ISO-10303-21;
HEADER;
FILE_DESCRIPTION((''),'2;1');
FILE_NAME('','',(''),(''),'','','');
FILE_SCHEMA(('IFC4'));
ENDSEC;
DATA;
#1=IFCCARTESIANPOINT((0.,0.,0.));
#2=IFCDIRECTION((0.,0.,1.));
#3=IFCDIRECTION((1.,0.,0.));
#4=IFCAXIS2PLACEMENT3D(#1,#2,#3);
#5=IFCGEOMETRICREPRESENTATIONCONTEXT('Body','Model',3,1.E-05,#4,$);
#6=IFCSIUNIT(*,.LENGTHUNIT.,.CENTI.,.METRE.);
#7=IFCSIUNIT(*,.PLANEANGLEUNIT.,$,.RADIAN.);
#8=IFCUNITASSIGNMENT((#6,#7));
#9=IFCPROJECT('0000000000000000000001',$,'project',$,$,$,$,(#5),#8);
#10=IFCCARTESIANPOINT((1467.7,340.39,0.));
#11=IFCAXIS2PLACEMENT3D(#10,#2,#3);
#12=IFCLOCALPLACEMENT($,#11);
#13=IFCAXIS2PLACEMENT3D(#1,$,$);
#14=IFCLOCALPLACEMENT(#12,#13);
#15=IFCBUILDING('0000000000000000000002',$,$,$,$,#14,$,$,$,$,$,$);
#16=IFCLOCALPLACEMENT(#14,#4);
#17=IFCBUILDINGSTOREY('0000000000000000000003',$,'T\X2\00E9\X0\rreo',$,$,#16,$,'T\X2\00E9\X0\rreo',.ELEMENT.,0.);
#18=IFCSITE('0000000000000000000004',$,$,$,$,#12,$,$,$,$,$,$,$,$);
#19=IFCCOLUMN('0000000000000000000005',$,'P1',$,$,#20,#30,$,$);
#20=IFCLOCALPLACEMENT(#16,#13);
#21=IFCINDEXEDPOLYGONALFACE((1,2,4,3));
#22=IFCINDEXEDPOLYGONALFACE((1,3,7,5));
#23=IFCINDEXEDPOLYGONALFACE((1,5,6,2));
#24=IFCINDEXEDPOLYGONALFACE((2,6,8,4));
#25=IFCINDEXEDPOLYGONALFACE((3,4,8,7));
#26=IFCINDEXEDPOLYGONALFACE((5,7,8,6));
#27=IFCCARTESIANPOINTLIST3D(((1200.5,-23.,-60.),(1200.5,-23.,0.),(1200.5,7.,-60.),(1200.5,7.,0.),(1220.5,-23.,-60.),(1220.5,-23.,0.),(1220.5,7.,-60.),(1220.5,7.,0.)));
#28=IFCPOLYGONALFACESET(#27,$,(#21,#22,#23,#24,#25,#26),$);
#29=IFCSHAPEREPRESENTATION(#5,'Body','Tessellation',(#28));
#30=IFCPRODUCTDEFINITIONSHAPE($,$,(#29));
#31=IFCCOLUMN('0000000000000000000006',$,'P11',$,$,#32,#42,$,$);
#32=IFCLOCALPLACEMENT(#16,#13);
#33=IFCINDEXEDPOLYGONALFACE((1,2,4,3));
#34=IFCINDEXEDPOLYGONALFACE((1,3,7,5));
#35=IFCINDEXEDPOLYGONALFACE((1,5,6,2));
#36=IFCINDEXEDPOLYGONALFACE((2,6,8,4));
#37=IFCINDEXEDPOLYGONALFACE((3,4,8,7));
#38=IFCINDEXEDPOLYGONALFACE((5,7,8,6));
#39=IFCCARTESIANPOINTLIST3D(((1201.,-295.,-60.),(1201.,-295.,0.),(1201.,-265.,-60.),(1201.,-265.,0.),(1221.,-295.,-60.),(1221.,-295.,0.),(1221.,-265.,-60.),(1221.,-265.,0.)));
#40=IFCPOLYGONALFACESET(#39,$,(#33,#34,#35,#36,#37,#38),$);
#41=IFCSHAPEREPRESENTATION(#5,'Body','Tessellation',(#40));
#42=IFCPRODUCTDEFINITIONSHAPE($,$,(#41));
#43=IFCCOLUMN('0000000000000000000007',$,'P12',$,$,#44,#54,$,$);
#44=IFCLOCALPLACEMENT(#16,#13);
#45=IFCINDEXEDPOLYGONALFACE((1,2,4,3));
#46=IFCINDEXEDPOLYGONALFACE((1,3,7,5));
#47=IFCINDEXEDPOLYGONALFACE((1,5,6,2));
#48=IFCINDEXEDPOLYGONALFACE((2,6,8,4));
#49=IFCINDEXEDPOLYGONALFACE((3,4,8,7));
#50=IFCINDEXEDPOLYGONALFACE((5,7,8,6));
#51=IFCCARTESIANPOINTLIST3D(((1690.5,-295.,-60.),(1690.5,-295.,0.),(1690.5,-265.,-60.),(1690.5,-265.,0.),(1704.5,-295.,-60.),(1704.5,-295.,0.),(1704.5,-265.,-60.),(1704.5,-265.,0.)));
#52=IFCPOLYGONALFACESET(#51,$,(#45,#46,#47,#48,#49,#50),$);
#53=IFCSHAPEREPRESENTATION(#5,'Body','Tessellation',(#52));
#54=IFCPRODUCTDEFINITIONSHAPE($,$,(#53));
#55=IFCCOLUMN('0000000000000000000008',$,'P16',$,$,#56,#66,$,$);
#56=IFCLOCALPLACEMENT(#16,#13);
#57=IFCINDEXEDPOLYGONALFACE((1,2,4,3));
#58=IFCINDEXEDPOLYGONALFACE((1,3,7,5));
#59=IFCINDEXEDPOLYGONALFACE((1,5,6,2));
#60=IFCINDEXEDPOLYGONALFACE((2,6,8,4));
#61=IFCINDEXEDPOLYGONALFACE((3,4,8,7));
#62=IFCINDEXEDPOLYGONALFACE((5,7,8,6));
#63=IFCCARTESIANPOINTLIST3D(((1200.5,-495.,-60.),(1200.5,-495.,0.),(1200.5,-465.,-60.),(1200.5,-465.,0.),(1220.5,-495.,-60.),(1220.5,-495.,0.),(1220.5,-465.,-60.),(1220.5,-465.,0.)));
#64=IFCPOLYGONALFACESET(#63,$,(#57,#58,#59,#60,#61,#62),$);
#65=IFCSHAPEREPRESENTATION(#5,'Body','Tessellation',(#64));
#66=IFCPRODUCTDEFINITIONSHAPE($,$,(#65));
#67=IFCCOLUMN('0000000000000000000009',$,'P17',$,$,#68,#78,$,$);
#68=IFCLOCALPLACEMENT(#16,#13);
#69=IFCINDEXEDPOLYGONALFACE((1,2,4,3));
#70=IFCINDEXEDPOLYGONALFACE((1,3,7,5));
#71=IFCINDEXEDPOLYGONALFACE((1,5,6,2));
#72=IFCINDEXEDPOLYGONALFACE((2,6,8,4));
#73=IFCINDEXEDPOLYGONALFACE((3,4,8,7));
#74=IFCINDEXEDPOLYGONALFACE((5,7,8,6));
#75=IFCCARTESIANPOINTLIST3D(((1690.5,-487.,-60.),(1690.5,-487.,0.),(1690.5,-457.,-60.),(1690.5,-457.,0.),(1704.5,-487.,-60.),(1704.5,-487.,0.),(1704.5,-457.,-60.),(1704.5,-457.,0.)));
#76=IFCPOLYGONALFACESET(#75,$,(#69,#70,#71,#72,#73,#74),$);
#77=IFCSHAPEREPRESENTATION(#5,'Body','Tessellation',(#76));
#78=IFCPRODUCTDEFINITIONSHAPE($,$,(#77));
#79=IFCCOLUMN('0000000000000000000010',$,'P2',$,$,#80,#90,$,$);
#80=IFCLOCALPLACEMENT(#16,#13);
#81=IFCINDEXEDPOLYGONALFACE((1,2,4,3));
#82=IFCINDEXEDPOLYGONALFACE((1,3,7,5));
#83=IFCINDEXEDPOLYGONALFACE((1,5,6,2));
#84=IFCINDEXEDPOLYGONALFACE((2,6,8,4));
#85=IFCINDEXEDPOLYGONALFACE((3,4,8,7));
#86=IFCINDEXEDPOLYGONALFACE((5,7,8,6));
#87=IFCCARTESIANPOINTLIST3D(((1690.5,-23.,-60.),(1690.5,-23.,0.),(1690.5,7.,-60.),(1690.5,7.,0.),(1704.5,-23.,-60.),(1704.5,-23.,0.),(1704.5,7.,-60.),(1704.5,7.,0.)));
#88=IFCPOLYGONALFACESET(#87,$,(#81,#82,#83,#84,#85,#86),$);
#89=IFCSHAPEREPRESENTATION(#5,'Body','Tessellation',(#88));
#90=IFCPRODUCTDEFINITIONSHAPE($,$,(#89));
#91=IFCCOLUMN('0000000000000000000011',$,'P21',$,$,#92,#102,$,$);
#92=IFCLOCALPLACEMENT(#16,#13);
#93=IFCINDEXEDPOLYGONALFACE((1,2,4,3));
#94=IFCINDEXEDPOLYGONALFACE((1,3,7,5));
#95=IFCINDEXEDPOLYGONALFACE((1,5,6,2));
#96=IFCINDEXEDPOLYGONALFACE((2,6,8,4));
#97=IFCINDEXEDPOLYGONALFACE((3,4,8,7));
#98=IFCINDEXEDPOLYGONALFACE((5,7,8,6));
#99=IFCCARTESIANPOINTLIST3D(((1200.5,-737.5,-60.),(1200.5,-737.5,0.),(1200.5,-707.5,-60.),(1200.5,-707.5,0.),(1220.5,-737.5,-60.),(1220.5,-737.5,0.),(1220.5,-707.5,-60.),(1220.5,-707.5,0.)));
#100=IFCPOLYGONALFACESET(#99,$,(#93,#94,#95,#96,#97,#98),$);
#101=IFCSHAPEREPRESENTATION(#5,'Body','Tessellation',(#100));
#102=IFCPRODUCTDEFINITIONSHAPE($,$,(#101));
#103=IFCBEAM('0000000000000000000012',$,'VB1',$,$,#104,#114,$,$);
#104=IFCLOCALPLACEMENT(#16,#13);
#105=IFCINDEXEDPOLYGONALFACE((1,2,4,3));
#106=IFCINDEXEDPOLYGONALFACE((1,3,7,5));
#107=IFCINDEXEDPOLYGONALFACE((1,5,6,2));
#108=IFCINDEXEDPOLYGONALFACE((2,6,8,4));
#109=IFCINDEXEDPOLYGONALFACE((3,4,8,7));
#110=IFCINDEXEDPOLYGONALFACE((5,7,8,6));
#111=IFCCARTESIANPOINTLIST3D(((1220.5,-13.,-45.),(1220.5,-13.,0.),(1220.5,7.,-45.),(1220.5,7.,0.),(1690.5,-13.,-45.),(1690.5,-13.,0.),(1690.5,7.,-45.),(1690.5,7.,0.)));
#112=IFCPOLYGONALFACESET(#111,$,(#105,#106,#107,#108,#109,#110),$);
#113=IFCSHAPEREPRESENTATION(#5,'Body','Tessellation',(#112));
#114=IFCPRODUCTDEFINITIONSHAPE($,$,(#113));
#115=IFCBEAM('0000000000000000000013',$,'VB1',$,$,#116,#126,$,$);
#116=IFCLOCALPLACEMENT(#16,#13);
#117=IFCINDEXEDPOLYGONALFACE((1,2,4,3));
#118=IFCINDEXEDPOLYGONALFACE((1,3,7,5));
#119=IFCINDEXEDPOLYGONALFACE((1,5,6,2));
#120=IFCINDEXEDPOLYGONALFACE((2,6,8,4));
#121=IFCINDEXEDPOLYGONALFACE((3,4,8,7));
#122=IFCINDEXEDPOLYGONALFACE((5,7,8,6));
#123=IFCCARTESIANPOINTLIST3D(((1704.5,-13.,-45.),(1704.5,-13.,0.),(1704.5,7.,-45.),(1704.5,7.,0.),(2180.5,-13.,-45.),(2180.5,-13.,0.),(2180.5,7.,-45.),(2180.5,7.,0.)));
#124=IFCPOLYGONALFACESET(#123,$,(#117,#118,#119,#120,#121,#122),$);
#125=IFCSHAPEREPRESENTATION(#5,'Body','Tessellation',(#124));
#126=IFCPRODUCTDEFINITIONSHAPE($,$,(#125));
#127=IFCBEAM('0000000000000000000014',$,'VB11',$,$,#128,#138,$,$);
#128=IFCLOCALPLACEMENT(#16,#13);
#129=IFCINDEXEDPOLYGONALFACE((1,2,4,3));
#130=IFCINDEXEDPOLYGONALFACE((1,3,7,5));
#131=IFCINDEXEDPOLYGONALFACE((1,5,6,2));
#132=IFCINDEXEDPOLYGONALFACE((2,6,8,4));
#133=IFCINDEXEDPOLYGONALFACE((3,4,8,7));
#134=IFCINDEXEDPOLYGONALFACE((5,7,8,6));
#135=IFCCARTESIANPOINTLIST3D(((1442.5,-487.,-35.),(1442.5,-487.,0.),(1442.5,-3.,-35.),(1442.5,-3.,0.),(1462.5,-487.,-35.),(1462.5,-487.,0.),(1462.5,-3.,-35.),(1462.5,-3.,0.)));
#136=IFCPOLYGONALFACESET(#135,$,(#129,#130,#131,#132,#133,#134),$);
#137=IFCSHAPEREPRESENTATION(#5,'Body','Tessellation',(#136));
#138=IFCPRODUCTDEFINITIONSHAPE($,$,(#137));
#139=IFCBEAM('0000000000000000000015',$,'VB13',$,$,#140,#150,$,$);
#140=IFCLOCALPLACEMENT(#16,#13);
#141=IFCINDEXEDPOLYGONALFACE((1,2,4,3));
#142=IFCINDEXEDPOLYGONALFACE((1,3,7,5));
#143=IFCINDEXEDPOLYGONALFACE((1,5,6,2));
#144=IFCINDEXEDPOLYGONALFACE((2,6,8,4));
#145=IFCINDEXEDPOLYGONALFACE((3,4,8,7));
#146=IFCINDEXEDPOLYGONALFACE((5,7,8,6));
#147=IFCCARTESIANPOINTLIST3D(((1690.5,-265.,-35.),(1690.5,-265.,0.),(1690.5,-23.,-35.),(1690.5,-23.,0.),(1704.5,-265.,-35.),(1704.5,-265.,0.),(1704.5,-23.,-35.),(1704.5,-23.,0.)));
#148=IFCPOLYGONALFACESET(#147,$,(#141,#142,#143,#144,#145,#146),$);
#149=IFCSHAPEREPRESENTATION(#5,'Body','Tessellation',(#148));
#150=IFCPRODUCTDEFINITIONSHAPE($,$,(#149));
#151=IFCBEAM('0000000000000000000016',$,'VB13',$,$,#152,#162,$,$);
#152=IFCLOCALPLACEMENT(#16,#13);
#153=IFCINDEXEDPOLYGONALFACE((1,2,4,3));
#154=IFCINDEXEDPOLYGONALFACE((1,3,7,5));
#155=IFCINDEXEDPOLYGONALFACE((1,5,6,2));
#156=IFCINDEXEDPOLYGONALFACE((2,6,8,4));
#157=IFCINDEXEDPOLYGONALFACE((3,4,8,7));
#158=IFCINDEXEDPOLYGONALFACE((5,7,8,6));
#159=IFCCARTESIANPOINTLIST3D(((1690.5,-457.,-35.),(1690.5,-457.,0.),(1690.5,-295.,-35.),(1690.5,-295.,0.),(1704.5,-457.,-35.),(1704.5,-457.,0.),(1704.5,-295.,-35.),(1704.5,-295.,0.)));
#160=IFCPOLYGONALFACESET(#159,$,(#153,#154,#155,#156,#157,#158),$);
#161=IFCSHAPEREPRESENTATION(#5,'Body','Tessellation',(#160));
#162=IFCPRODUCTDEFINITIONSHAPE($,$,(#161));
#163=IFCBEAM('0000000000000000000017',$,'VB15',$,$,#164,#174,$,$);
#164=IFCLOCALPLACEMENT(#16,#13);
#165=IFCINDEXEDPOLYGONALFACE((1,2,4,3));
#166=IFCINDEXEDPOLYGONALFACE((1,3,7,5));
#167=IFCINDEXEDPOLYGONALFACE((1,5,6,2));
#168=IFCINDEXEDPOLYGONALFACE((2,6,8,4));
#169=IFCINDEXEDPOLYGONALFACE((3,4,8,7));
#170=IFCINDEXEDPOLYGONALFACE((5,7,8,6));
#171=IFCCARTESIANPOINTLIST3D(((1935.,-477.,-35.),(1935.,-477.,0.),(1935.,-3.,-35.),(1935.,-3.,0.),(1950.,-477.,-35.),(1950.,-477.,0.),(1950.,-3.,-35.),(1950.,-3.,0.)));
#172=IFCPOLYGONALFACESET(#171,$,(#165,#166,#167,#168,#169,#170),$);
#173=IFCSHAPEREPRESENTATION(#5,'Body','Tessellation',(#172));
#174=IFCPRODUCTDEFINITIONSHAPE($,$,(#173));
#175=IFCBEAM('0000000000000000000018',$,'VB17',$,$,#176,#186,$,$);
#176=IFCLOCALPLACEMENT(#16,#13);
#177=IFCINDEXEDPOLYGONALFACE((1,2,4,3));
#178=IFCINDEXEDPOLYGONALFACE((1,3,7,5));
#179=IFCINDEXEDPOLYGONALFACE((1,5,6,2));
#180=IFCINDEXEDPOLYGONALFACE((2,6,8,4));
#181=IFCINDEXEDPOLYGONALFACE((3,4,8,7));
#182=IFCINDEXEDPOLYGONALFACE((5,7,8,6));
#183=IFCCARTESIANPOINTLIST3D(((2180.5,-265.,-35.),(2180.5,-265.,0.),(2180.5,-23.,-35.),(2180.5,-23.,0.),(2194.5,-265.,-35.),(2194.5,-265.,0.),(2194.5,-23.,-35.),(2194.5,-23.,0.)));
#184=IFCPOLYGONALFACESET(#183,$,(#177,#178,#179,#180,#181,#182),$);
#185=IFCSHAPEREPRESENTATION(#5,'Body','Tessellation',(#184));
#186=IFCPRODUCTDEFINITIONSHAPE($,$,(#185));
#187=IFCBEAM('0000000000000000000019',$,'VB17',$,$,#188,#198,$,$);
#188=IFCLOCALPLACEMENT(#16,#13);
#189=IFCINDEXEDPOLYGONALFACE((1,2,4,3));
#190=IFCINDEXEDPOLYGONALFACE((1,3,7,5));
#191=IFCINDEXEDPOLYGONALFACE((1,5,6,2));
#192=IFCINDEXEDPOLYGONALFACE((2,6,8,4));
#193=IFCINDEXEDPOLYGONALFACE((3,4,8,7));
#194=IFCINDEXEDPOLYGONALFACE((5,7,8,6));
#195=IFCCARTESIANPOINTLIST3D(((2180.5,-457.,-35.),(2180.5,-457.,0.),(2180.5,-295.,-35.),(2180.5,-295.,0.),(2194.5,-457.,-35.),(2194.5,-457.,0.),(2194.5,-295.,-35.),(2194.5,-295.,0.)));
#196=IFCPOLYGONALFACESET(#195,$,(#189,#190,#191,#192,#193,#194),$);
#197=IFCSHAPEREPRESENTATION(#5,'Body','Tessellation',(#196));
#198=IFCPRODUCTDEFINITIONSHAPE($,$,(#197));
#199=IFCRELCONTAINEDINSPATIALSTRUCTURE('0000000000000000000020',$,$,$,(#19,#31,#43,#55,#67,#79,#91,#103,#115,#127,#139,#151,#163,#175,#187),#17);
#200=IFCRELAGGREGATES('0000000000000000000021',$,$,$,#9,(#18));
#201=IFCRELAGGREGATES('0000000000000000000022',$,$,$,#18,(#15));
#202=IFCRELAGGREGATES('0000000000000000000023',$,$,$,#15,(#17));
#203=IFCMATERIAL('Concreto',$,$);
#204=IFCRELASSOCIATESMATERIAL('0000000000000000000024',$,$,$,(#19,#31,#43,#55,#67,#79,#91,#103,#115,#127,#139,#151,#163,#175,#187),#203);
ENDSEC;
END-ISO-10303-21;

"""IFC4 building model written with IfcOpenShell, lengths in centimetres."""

from ifc_helpers import new_model, si_unit, frame, origin, origin_with_axes, origin_2d_with_axis, place, context, project, spatial, rectangle, extrude, material, element, save


model = new_model("IFC4")

# Units and contexts
model_context = context("Model", 3, precision=1e-05, world=origin_with_axes(), identifier="Body")
ifc_project = project(units=[si_unit("LENGTHUNIT", "METRE", prefix="CENTI"), si_unit("PLANEANGLEUNIT", "RADIAN")], contexts=[model_context])

# Site, building, storey
site_placement = place(None, frame((1467.7, 340.39, 0.0), z_axis=(0.0, 0.0, 1.0), x_axis=(1.0, 0.0, 0.0)))
site = spatial("IfcSite", under=ifc_project, at=site_placement)
building_placement = place(site_placement, origin())
building = spatial("IfcBuilding", under=site, at=building_placement)
storey_placement = place(building_placement, origin_with_axes())
storey = spatial("IfcBuildingStorey", under=building, at=storey_placement, Name="Térreo", LongName="Térreo", CompositionType="ELEMENT", Elevation=0.0)

# Columns
ifc_material = material(Name="Concreto")
for number, where, z_axis, x_axis, name in (
    (1, (1210.5, -8.0, 0.0), (0.0, 0.0, 1.0), (1.0, 0.0, 0.0), "P1"),
    (2, (1211.0, -280.0, 0.0), (0.0, 0.0, 1.0), (1.0, 0.0, 0.0), "P11"),
):
    element("IfcColumn", number, at=place(storey_placement, frame(where, z_axis=z_axis, x_axis=x_axis)), inside=storey, material=ifc_material, Name=name, context=model_context, shape_type="SolidModel", body=[
        extrude(rectangle(XDim=20.0, YDim=30.0, at=origin_2d_with_axis()), frame((0.0, 0.0, -60.0), z_axis=(0.0, 0.0, 1.0), x_axis=(1.0, 0.0, 0.0)), (0.0, 0.0, 1.0), 60.0),
    ])
column_1_placement = place(storey_placement, frame((1697.5, -280.0, 0.0), z_axis=(0.0, 0.0, 1.0), x_axis=(1.0, 0.0, 0.0)))
element("IfcColumn", 3, at=column_1_placement, inside=storey, material=ifc_material, Name="P12", context=model_context, shape_type="SolidModel", body=[
    extrude(rectangle(XDim=14.0, YDim=30.0, at=origin_2d_with_axis()), frame((0.0, 0.0, -60.0), z_axis=(0.0, 0.0, 1.0), x_axis=(1.0, 0.0, 0.0)), (0.0, 0.0, 1.0), 60.0),
])
column_2_placement = place(storey_placement, frame((1210.5, -480.0, 0.0), z_axis=(0.0, 0.0, 1.0), x_axis=(1.0, 0.0, 0.0)))
element("IfcColumn", 4, at=column_2_placement, inside=storey, material=ifc_material, Name="P16", context=model_context, shape_type="SolidModel", body=[
    extrude(rectangle(XDim=20.0, YDim=30.0, at=origin_2d_with_axis()), frame((0.0, 0.0, -60.0), z_axis=(0.0, 0.0, 1.0), x_axis=(1.0, 0.0, 0.0)), (0.0, 0.0, 1.0), 60.0),
])
column_3_placement = place(storey_placement, frame((1697.5, -472.0, 0.0), z_axis=(0.0, 0.0, 1.0), x_axis=(1.0, 0.0, 0.0)))
element("IfcColumn", 5, at=column_3_placement, inside=storey, material=ifc_material, Name="P17", context=model_context, shape_type="SolidModel", body=[
    extrude(rectangle(XDim=14.0, YDim=30.0, at=origin_2d_with_axis()), frame((0.0, 0.0, -60.0), z_axis=(0.0, 0.0, 1.0), x_axis=(-1.0, 0.0, 0.0)), (0.0, 0.0, 1.0), 60.0),
])
column_4_placement = place(storey_placement, frame((1697.5, -8.0, 0.0), z_axis=(0.0, 0.0, 1.0), x_axis=(1.0, 0.0, 0.0)))
element("IfcColumn", 6, at=column_4_placement, inside=storey, material=ifc_material, Name="P2", context=model_context, shape_type="SolidModel", body=[
    extrude(rectangle(XDim=14.0, YDim=30.0, at=origin_2d_with_axis()), frame((0.0, 0.0, -60.0), z_axis=(0.0, 0.0, 1.0), x_axis=(1.0, 0.0, 0.0)), (0.0, 0.0, 1.0), 60.0),
])
column_5_placement = place(storey_placement, frame((1210.5, -722.5, 0.0), z_axis=(0.0, 0.0, 1.0), x_axis=(1.0, 0.0, 0.0)))
element("IfcColumn", 7, at=column_5_placement, inside=storey, material=ifc_material, Name="P21", context=model_context, shape_type="SolidModel", body=[
    extrude(rectangle(XDim=20.0, YDim=30.0, at=origin_2d_with_axis()), frame((0.0, 0.0, -60.0), z_axis=(0.0, 0.0, 1.0), x_axis=(1.0, 0.0, 0.0)), (0.0, 0.0, 1.0), 60.0),
])

# Beams
beam_1_placement = place(storey_placement, frame((1455.5, -3.0, 0.0), z_axis=(0.0, 0.0, 1.0), x_axis=(1.0, 0.0, 0.0)))
element("IfcBeam", 8, at=beam_1_placement, inside=storey, material=ifc_material, Name="VB1", context=model_context, shape_type="SolidModel", body=[
    extrude(rectangle(XDim=20.0, YDim=45.0, at=origin_2d_with_axis()), frame((-235.0, 0.0, -22.5), z_axis=(1.0, 0.0, 0.0), x_axis=(0.0, 1.0, 0.0)), (0.0, 0.0, 1.0), 470.0),
])
beam_2_placement = place(storey_placement, frame((1942.5, -3.0, 0.0), z_axis=(0.0, 0.0, 1.0), x_axis=(1.0, 0.0, 0.0)))
element("IfcBeam", 9, at=beam_2_placement, inside=storey, material=ifc_material, Name="VB1", context=model_context, shape_type="SolidModel", body=[
    extrude(rectangle(XDim=20.0, YDim=45.0, at=origin_2d_with_axis()), frame((-238.0, 0.0, -22.5), z_axis=(1.0, 0.0, 0.0), x_axis=(0.0, 1.0, 0.0)), (0.0, 0.0, 1.0), 476.0),
])
beam_3_placement = place(storey_placement, frame((1452.5, -245.0, 0.0), z_axis=(0.0, 0.0, 1.0), x_axis=(1.0, 0.0, 0.0)))
element("IfcBeam", 10, at=beam_3_placement, inside=storey, material=ifc_material, Name="VB11", context=model_context, shape_type="SolidModel", body=[
    extrude(rectangle(XDim=20.0, YDim=35.0, at=origin_2d_with_axis()), frame((0.0, -242.0, -17.5), z_axis=(0.0, 1.0, 0.0), x_axis=(1.0, 0.0, 0.0)), (0.0, 0.0, 1.0), 484.0),
])
beam_4_placement = place(storey_placement, frame((1697.5, -144.0, 0.0), z_axis=(0.0, 0.0, 1.0), x_axis=(1.0, 0.0, 0.0)))
element("IfcBeam", 11, at=beam_4_placement, inside=storey, material=ifc_material, Name="VB13", context=model_context, shape_type="SolidModel", body=[
    extrude(rectangle(XDim=14.0, YDim=35.0, at=origin_2d_with_axis()), frame((0.0, -121.0, -17.5), z_axis=(0.0, 1.0, 0.0), x_axis=(1.0, 0.0, 0.0)), (0.0, 0.0, 1.0), 242.0),
])
beam_5_placement = place(storey_placement, frame((1697.5, -376.0, 0.0), z_axis=(0.0, 0.0, 1.0), x_axis=(1.0, 0.0, 0.0)))
element("IfcBeam", 12, at=beam_5_placement, inside=storey, material=ifc_material, Name="VB13", context=model_context, shape_type="SolidModel", body=[
    extrude(rectangle(XDim=14.0, YDim=35.0, at=origin_2d_with_axis()), frame((0.0, -81.0, -17.5), z_axis=(0.0, 1.0, 0.0), x_axis=(1.0, 0.0, 0.0)), (0.0, 0.0, 1.0), 162.0),
])
beam_6_placement = place(storey_placement, frame((1942.5, -240.0, 0.0), z_axis=(0.0, 0.0, 1.0), x_axis=(1.0, 0.0, 0.0)))
element("IfcBeam", 13, at=beam_6_placement, inside=storey, material=ifc_material, Name="VB15", context=model_context, shape_type="SolidModel", body=[
    extrude(rectangle(XDim=15.0, YDim=35.0, at=origin_2d_with_axis()), frame((0.0, -237.0, -17.5), z_axis=(0.0, 1.0, 0.0), x_axis=(1.0, 0.0, 0.0)), (0.0, 0.0, 1.0), 474.0),
])
beam_7_placement = place(storey_placement, frame((2187.5, -144.0, 0.0), z_axis=(0.0, 0.0, 1.0), x_axis=(1.0, 0.0, 0.0)))
element("IfcBeam", 14, at=beam_7_placement, inside=storey, material=ifc_material, Name="VB17", context=model_context, shape_type="SolidModel", body=[
    extrude(rectangle(XDim=14.0, YDim=35.0, at=origin_2d_with_axis()), frame((0.0, -121.0, -17.5), z_axis=(0.0, 1.0, 0.0), x_axis=(1.0, 0.0, 0.0)), (0.0, 0.0, 1.0), 242.0),
])
beam_8_placement = place(storey_placement, frame((2187.5, -376.0, 0.0), z_axis=(0.0, 0.0, 1.0), x_axis=(1.0, 0.0, 0.0)))
element("IfcBeam", 15, at=beam_8_placement, inside=storey, material=ifc_material, Name="VB17", context=model_context, shape_type="SolidModel", body=[
    extrude(rectangle(XDim=14.0, YDim=35.0, at=origin_2d_with_axis()), frame((0.0, -81.0, -17.5), z_axis=(0.0, 1.0, 0.0), x_axis=(1.0, 0.0, 0.0)), (0.0, 0.0, 1.0), 162.0),
])

save(model, "model.ifc")
